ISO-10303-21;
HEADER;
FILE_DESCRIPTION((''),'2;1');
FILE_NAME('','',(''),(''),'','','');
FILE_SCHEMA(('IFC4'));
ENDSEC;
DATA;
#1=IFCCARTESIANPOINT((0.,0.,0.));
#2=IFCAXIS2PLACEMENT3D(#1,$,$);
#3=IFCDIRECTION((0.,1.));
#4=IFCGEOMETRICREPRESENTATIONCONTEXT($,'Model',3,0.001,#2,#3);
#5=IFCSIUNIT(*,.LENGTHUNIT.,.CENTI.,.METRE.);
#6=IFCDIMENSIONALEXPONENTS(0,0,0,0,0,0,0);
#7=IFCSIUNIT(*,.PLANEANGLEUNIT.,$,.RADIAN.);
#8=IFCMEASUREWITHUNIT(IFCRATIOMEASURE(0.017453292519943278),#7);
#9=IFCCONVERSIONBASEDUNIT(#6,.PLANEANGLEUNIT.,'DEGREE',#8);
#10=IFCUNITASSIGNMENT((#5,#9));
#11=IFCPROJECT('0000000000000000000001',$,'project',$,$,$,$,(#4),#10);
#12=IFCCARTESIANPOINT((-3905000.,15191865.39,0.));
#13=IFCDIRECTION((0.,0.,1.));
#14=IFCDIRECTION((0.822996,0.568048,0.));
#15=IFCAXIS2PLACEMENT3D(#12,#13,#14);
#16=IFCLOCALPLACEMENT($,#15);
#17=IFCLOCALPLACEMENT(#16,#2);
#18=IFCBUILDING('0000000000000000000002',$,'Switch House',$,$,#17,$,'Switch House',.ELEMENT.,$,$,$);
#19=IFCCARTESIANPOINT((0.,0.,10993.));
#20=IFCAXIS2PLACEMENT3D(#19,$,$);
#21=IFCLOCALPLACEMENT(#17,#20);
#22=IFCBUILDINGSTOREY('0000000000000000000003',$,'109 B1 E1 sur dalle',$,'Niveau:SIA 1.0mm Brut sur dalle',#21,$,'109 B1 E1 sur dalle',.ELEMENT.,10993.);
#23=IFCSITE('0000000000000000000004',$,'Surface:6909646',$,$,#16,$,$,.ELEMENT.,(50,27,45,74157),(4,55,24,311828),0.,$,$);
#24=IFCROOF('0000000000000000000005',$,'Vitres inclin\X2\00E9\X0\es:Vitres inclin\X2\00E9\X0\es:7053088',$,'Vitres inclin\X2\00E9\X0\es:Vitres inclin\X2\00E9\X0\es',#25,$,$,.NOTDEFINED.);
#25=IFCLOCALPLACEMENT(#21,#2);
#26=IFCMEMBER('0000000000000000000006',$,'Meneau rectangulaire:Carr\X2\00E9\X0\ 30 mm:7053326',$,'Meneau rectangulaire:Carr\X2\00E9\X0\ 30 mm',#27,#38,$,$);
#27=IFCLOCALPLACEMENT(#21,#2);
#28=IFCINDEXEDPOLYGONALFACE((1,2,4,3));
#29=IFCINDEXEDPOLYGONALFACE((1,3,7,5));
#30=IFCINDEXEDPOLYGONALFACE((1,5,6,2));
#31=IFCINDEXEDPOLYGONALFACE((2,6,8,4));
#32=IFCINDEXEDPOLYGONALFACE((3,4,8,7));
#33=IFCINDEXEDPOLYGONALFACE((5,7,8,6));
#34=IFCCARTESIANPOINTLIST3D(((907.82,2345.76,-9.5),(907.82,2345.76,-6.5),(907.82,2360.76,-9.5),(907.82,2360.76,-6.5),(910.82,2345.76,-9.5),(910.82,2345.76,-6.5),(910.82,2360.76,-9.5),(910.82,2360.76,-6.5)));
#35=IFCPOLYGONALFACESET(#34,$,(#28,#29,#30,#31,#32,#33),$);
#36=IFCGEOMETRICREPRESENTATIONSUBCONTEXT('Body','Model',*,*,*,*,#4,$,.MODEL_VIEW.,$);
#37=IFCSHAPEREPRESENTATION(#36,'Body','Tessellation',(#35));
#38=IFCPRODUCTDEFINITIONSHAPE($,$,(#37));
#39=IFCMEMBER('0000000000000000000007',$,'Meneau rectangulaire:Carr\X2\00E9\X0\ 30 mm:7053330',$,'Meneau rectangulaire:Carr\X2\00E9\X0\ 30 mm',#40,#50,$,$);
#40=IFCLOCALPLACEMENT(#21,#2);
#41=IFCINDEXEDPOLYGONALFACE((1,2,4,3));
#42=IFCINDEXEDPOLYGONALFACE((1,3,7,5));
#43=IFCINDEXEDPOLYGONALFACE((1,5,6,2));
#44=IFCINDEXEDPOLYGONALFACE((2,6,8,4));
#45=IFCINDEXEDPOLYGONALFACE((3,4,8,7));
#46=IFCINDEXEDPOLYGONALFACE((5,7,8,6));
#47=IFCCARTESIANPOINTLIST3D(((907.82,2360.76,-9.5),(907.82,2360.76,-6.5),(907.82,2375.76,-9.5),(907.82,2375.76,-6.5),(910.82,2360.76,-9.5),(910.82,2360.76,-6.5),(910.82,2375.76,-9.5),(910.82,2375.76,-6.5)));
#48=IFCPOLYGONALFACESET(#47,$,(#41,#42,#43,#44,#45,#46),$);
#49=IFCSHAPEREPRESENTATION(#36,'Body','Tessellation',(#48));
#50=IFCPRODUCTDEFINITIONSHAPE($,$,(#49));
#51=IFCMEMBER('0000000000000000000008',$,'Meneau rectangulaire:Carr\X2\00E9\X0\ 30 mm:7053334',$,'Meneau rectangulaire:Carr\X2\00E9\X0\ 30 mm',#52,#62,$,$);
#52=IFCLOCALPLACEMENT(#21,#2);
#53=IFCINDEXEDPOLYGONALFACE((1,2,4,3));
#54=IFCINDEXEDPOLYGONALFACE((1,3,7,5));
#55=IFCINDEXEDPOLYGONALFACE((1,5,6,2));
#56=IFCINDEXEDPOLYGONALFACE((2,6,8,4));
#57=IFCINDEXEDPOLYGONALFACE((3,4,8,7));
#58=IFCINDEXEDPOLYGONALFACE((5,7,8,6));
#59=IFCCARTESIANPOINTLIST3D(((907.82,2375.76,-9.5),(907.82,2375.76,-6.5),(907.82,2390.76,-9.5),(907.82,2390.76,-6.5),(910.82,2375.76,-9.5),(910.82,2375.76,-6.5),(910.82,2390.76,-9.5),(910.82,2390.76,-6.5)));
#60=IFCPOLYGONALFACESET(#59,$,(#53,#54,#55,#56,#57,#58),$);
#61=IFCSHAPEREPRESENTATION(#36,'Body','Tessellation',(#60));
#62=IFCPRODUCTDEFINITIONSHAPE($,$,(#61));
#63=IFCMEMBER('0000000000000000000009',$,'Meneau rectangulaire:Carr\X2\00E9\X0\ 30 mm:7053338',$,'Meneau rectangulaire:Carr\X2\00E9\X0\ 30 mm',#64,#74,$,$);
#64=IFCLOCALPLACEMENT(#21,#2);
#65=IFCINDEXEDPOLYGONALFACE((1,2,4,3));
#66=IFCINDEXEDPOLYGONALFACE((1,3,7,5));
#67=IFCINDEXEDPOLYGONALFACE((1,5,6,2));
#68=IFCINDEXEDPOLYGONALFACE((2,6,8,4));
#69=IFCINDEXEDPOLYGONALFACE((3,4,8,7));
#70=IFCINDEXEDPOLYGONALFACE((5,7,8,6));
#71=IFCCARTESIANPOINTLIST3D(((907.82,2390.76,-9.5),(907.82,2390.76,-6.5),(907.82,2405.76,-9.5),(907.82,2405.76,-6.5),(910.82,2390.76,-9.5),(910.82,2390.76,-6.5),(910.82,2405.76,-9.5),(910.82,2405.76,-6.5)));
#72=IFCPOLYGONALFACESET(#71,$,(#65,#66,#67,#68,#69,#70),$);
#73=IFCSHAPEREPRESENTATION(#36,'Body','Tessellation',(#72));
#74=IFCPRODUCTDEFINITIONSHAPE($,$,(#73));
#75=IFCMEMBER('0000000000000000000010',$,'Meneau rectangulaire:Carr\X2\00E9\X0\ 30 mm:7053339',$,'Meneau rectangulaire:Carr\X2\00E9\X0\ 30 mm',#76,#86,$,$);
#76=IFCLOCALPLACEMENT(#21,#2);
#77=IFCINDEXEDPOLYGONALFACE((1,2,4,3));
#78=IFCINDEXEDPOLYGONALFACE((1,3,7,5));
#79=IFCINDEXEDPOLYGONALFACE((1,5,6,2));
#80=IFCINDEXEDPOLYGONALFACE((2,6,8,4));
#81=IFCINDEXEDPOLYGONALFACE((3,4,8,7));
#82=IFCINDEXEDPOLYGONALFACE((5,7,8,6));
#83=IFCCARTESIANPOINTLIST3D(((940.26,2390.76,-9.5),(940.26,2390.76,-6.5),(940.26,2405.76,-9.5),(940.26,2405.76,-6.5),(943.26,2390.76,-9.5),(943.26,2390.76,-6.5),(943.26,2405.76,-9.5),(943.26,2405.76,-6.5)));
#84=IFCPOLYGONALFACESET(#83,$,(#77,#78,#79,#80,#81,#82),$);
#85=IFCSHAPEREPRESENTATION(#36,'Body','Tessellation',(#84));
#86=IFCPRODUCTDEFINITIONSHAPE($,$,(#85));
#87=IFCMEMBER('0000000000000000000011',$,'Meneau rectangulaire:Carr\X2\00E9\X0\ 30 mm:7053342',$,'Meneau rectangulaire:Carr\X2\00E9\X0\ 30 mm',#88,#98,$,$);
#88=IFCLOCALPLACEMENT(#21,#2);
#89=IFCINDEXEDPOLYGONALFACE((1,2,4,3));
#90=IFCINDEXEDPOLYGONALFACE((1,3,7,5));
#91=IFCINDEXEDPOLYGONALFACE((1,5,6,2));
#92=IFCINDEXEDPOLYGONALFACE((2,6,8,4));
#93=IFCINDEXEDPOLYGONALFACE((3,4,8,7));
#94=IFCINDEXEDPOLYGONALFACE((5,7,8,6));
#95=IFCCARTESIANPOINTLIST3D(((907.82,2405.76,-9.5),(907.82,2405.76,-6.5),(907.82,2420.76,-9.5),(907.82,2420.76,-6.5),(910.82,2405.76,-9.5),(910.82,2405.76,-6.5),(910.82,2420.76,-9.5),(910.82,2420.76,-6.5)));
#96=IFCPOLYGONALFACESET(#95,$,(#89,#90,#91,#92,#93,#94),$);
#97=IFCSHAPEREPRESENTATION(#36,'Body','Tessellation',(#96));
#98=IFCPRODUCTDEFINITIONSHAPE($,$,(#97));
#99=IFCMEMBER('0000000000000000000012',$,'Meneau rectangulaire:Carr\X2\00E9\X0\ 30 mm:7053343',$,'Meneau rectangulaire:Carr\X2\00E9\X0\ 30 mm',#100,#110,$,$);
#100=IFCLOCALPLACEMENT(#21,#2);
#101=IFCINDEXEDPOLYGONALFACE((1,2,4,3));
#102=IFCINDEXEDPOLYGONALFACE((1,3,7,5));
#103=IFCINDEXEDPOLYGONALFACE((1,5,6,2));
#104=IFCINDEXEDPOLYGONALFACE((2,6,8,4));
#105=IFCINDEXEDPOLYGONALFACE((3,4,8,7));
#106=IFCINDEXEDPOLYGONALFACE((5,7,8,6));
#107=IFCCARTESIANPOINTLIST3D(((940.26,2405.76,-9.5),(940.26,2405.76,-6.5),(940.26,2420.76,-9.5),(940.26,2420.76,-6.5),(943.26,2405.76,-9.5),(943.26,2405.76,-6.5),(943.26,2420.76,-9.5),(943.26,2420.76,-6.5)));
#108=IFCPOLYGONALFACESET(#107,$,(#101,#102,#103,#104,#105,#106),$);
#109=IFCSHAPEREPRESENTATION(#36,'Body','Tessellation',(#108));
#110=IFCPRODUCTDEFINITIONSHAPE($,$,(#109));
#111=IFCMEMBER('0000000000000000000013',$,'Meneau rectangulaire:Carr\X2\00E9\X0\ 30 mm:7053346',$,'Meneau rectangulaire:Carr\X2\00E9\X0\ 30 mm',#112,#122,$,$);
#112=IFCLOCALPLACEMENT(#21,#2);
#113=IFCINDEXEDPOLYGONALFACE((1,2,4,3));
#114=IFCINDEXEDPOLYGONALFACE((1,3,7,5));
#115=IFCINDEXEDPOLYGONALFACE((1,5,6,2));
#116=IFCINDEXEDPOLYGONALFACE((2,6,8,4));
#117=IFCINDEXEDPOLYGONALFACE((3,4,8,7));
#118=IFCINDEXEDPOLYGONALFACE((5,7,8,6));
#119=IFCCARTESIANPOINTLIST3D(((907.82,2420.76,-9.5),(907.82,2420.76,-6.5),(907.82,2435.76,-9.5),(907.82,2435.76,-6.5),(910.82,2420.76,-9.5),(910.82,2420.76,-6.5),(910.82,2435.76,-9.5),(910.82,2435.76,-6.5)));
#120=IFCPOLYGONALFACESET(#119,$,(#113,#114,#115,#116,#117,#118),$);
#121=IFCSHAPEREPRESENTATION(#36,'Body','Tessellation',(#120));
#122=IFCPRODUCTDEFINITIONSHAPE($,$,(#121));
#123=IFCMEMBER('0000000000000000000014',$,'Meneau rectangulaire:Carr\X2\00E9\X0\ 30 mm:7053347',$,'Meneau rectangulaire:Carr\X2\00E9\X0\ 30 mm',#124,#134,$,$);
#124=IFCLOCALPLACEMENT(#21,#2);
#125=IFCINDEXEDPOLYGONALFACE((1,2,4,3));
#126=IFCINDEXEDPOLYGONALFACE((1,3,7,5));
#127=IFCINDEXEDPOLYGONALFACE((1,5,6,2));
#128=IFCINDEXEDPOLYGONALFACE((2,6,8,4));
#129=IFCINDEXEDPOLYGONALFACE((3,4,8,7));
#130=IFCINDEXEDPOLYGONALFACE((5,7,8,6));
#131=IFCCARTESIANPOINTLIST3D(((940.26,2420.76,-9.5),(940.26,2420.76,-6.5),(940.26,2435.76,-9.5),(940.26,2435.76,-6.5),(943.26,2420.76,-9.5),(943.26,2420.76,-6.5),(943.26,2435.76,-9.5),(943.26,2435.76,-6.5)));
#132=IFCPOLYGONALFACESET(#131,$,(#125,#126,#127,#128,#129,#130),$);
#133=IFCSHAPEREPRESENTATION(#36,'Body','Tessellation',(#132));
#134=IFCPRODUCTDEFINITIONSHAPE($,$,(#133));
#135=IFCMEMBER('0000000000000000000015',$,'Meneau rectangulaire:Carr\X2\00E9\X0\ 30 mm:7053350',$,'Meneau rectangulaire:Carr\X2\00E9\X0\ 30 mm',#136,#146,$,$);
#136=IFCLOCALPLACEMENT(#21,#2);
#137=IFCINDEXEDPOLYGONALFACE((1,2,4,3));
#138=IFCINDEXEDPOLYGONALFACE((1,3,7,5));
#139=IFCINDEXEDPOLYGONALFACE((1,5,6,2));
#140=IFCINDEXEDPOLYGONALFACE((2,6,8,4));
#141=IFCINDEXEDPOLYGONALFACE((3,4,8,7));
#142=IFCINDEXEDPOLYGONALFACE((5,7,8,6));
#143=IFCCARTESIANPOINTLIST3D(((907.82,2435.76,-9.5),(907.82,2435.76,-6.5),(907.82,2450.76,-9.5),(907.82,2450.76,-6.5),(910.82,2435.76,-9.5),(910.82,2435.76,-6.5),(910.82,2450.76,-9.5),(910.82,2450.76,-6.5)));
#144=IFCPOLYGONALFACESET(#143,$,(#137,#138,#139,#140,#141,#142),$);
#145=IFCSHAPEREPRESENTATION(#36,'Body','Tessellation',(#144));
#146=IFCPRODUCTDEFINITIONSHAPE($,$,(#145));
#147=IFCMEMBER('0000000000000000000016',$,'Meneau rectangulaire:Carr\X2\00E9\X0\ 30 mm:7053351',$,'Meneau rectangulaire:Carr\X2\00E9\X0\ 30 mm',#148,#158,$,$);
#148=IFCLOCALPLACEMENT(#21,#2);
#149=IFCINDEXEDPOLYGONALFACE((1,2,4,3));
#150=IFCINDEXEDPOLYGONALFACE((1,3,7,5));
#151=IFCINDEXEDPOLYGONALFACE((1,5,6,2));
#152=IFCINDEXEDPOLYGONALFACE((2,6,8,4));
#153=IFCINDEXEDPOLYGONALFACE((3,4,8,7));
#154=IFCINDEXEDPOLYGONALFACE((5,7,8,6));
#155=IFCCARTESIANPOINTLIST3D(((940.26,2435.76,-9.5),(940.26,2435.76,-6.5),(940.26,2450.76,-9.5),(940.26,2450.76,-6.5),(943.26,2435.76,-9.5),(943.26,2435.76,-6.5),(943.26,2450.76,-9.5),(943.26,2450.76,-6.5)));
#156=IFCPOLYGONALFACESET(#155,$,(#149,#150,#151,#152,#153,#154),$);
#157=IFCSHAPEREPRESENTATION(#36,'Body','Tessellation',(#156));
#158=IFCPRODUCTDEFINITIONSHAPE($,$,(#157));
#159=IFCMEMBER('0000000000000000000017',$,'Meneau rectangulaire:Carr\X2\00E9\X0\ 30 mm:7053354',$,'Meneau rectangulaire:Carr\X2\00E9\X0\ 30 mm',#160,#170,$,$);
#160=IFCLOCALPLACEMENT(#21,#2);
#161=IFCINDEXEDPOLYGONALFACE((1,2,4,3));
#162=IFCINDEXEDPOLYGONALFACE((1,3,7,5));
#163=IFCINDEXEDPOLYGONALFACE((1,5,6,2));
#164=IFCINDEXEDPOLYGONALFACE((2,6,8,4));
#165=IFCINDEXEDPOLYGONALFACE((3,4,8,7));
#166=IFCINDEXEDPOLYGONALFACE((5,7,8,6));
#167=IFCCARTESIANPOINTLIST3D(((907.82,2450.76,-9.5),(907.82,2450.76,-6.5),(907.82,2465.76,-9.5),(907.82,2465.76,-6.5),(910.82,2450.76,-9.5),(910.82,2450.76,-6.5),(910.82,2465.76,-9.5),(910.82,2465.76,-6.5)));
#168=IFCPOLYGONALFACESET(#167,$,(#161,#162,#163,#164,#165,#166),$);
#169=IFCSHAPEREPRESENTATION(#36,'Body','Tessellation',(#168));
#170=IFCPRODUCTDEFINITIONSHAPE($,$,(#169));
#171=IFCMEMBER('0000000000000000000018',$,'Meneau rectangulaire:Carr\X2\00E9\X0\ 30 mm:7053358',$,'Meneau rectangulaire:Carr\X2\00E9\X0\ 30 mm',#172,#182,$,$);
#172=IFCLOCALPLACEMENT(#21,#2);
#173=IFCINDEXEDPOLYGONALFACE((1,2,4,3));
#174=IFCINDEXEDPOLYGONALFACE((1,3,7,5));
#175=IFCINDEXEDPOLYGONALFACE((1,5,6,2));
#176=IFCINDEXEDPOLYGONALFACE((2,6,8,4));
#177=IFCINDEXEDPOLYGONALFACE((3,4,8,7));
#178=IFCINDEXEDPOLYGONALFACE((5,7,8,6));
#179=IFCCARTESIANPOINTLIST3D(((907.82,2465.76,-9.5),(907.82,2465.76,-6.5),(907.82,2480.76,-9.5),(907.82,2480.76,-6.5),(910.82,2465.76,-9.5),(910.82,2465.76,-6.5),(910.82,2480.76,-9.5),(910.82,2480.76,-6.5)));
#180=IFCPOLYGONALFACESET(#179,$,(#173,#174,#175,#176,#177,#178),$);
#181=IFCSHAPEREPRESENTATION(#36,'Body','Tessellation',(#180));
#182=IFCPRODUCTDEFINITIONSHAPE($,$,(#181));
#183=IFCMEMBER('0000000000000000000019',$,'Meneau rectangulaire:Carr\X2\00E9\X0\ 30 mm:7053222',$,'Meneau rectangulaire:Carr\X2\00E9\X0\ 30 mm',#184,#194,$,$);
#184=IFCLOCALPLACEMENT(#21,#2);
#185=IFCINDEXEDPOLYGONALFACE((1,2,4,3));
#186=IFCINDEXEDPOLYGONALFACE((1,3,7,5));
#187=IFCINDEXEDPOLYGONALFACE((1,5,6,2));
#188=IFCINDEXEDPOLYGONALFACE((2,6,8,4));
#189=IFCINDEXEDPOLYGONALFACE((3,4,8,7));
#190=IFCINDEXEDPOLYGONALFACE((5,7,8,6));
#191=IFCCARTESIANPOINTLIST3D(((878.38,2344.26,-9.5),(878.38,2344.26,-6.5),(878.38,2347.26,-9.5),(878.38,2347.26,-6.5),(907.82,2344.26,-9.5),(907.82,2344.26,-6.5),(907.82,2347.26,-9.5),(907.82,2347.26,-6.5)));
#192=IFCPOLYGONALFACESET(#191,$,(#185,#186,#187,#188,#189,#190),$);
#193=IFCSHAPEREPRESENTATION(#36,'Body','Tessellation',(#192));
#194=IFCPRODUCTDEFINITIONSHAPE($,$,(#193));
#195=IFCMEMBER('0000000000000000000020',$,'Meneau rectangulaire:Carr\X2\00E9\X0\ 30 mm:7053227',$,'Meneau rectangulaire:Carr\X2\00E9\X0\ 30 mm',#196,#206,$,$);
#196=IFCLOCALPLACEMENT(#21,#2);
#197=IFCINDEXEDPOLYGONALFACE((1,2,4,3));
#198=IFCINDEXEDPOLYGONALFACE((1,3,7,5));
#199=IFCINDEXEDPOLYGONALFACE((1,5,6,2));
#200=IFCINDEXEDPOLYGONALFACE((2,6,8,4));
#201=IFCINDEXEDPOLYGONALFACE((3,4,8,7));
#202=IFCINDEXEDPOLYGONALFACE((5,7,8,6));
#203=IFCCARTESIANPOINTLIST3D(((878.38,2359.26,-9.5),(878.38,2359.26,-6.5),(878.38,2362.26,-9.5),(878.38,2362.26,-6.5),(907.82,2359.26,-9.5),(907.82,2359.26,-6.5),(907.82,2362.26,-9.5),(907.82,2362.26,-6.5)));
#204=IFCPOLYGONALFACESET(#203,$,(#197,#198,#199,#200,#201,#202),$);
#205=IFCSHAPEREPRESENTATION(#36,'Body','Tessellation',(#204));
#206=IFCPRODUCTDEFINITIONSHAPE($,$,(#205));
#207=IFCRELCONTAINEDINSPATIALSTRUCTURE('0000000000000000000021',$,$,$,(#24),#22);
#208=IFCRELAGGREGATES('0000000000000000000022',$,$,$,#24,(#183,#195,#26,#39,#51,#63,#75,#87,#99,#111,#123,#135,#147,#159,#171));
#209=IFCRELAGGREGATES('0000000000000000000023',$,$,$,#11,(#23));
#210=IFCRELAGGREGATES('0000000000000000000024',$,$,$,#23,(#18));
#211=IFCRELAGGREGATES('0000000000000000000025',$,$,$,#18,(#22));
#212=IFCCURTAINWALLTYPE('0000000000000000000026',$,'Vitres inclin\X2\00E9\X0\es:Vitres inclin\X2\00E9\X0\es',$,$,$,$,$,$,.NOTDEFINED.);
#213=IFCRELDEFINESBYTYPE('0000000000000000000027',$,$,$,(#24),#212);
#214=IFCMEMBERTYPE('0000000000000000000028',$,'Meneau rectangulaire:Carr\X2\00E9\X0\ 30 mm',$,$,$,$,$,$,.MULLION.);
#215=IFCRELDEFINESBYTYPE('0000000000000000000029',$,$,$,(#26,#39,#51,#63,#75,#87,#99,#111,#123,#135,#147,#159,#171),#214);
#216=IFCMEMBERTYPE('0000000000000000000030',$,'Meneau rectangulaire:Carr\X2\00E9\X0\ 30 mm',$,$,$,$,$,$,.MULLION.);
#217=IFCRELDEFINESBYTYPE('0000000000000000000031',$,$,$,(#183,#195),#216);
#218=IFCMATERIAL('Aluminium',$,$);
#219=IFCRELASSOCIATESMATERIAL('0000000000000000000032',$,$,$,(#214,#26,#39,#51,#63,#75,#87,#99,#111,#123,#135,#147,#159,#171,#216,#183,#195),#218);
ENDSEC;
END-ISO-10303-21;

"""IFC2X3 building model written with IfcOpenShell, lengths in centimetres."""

from ifc_helpers import new_model, entity, si_unit, converted_unit, direction, frame, origin, origin_2d_with_axis, place, context, subcontext, project, spatial, rectangle, extrude, source, transform, mapped, material, type_object, type_shapes, element, aggregate, save


model = new_model("IFC2X3")

# Units and contexts
model_context = context("Model", 3, precision=0.001, world=origin(), true_north=direction((0.0, 1.0)))
body_context = subcontext(model_context, "Body", "Model", "MODEL_VIEW")
ifc_project = project(units=[si_unit("LENGTHUNIT", "METRE", prefix="CENTI"), converted_unit("PLANEANGLEUNIT", "DEGREE", entity("IfcRatioMeasure", 0.017453292519943278), si_unit("PLANEANGLEUNIT", "RADIAN"), dimensions=[0, 0, 0, 0, 0, 0, 0])], contexts=[model_context])

# Site, building, storey
site_placement = place(None, frame((-3905000.0, 15191865.39, 0.0), z_axis=(0.0, 0.0, 1.0), x_axis=(0.822996, 0.568048, 0.0)))
site = spatial("IfcSite", under=ifc_project, at=site_placement, Name="Surface:6909646", CompositionType="ELEMENT", RefLatitude=(50, 27, 45, 74157), RefLongitude=(4, 55, 24, 311828), RefElevation=0.0)
building_placement = place(site_placement, origin())
building = spatial("IfcBuilding", under=site, at=building_placement, Name="Switch House", LongName="Switch House", CompositionType="ELEMENT")
storey_placement = place(building_placement, frame((0.0, 0.0, 10993.0)))
storey = spatial("IfcBuildingStorey", under=building, at=storey_placement, Name="109 B1 E1 sur dalle", ObjectType="Niveau:SIA 1.0mm Brut sur dalle", LongName="109 B1 E1 sur dalle", CompositionType="ELEMENT", Elevation=10993.0)

# Roof, members
curtain_wall_type = type_object("IfcCurtainWallType", Name="Vitres inclinées:Vitres inclinées", PredefinedType="NOTDEFINED")
roof_placement = place(storey_placement, frame((0.0, 0.0, -10993.0)))
roof = element("IfcRoof", 1, at=roof_placement, inside=storey, type_object=curtain_wall_type, Name="Vitres inclinées:Vitres inclinées:7053088", ObjectType="Vitres inclinées:Vitres inclinées", ShapeType="NOTDEFINED")
ifc_material = material(Name="Aluminium")
member_type_1 = type_object("IfcMemberType", Name="Meneau rectangulaire:Carré 30 mm", PredefinedType="MULLION", material=ifc_material)
shared_shape_1 = source(origin(), body_context, "Body", "SweptSolid", [
    extrude(rectangle(XDim=3.0, YDim=3.0, at=origin_2d_with_axis()), frame((0.0, 0.0, -15.0), z_axis=(0.0, 0.0, 1.0), x_axis=(0.0, -1.0, 0.0)), (0.0, 0.0, 1.0), 15.0),
])
type_shapes(member_type_1, [shared_shape_1])
member_1_placement = place(roof_placement, frame((909.32, 2360.76, 10985.0), z_axis=(0.0, 1.0, 0.0), x_axis=(1.0, 0.0, 0.0)))
member_1 = element("IfcMember", 2, at=member_1_placement, type_object=member_type_1, material=ifc_material, Name="Meneau rectangulaire:Carré 30 mm:7053326", ObjectType="Meneau rectangulaire:Carré 30 mm", context=body_context, shape_type="MappedRepresentation", body=[
    mapped(shared_shape_1, transform((0.0, 0.0, 0.0), scale=1.0)),
])
member_2_placement = place(roof_placement, frame((909.32, 2375.76, 10985.0), z_axis=(0.0, 1.0, 0.0), x_axis=(1.0, 0.0, 0.0)))
member_2 = element("IfcMember", 3, at=member_2_placement, type_object=member_type_1, material=ifc_material, Name="Meneau rectangulaire:Carré 30 mm:7053330", ObjectType="Meneau rectangulaire:Carré 30 mm", context=body_context, shape_type="MappedRepresentation", body=[
    mapped(shared_shape_1, transform((0.0, 0.0, 0.0), scale=1.0)),
])
member_3_placement = place(roof_placement, frame((909.32, 2390.76, 10985.0), z_axis=(0.0, 1.0, 0.0), x_axis=(1.0, 0.0, 0.0)))
member_3 = element("IfcMember", 4, at=member_3_placement, type_object=member_type_1, material=ifc_material, Name="Meneau rectangulaire:Carré 30 mm:7053334", ObjectType="Meneau rectangulaire:Carré 30 mm", context=body_context, shape_type="MappedRepresentation", body=[
    mapped(shared_shape_1, transform((0.0, 0.0, 0.0), scale=1.0)),
])
member_4_placement = place(roof_placement, frame((909.32, 2405.76, 10985.0), z_axis=(0.0, 1.0, 0.0), x_axis=(1.0, 0.0, 0.0)))
member_4 = element("IfcMember", 5, at=member_4_placement, type_object=member_type_1, material=ifc_material, Name="Meneau rectangulaire:Carré 30 mm:7053338", ObjectType="Meneau rectangulaire:Carré 30 mm", context=body_context, shape_type="MappedRepresentation", body=[
    mapped(shared_shape_1, transform((0.0, 0.0, 0.0), scale=1.0)),
])
member_5_placement = place(roof_placement, frame((941.76, 2405.76, 10985.0), z_axis=(0.0, 1.0, 0.0), x_axis=(1.0, 0.0, 0.0)))
member_5 = element("IfcMember", 6, at=member_5_placement, type_object=member_type_1, material=ifc_material, Name="Meneau rectangulaire:Carré 30 mm:7053339", ObjectType="Meneau rectangulaire:Carré 30 mm", context=body_context, shape_type="MappedRepresentation", body=[
    mapped(shared_shape_1, transform((0.0, 0.0, 0.0), scale=1.0)),
])
member_6_placement = place(roof_placement, frame((909.32, 2420.76, 10985.0), z_axis=(0.0, 1.0, 0.0), x_axis=(1.0, 0.0, 0.0)))
member_6 = element("IfcMember", 7, at=member_6_placement, type_object=member_type_1, material=ifc_material, Name="Meneau rectangulaire:Carré 30 mm:7053342", ObjectType="Meneau rectangulaire:Carré 30 mm", context=body_context, shape_type="MappedRepresentation", body=[
    mapped(shared_shape_1, transform((0.0, 0.0, 0.0), scale=1.0)),
])
member_7_placement = place(roof_placement, frame((941.76, 2420.76, 10985.0), z_axis=(0.0, 1.0, 0.0), x_axis=(1.0, 0.0, 0.0)))
member_7 = element("IfcMember", 8, at=member_7_placement, type_object=member_type_1, material=ifc_material, Name="Meneau rectangulaire:Carré 30 mm:7053343", ObjectType="Meneau rectangulaire:Carré 30 mm", context=body_context, shape_type="MappedRepresentation", body=[
    mapped(shared_shape_1, transform((0.0, 0.0, 0.0), scale=1.0)),
])
member_8_placement = place(roof_placement, frame((909.32, 2435.76, 10985.0), z_axis=(0.0, 1.0, 0.0), x_axis=(1.0, 0.0, 0.0)))
member_8 = element("IfcMember", 9, at=member_8_placement, type_object=member_type_1, material=ifc_material, Name="Meneau rectangulaire:Carré 30 mm:7053346", ObjectType="Meneau rectangulaire:Carré 30 mm", context=body_context, shape_type="MappedRepresentation", body=[
    mapped(shared_shape_1, transform((0.0, 0.0, 0.0), scale=1.0)),
])
member_9_placement = place(roof_placement, frame((941.76, 2435.76, 10985.0), z_axis=(0.0, 1.0, 0.0), x_axis=(1.0, 0.0, 0.0)))
member_9 = element("IfcMember", 10, at=member_9_placement, type_object=member_type_1, material=ifc_material, Name="Meneau rectangulaire:Carré 30 mm:7053347", ObjectType="Meneau rectangulaire:Carré 30 mm", context=body_context, shape_type="MappedRepresentation", body=[
    mapped(shared_shape_1, transform((0.0, 0.0, 0.0), scale=1.0)),
])
member_10_placement = place(roof_placement, frame((909.32, 2450.76, 10985.0), z_axis=(0.0, 1.0, 0.0), x_axis=(1.0, 0.0, 0.0)))
member_10 = element("IfcMember", 11, at=member_10_placement, type_object=member_type_1, material=ifc_material, Name="Meneau rectangulaire:Carré 30 mm:7053350", ObjectType="Meneau rectangulaire:Carré 30 mm", context=body_context, shape_type="MappedRepresentation", body=[
    mapped(shared_shape_1, transform((0.0, 0.0, 0.0), scale=1.0)),
])
member_11_placement = place(roof_placement, frame((941.76, 2450.76, 10985.0), z_axis=(0.0, 1.0, 0.0), x_axis=(1.0, 0.0, 0.0)))
member_11 = element("IfcMember", 12, at=member_11_placement, type_object=member_type_1, material=ifc_material, Name="Meneau rectangulaire:Carré 30 mm:7053351", ObjectType="Meneau rectangulaire:Carré 30 mm", context=body_context, shape_type="MappedRepresentation", body=[
    mapped(shared_shape_1, transform((0.0, 0.0, 0.0), scale=1.0)),
])
member_12_placement = place(roof_placement, frame((909.32, 2465.76, 10985.0), z_axis=(0.0, 1.0, 0.0), x_axis=(1.0, 0.0, 0.0)))
member_12 = element("IfcMember", 13, at=member_12_placement, type_object=member_type_1, material=ifc_material, Name="Meneau rectangulaire:Carré 30 mm:7053354", ObjectType="Meneau rectangulaire:Carré 30 mm", context=body_context, shape_type="MappedRepresentation", body=[
    mapped(shared_shape_1, transform((0.0, 0.0, 0.0), scale=1.0)),
])
member_13_placement = place(roof_placement, frame((909.32, 2480.76, 10985.0), z_axis=(0.0, 1.0, 0.0), x_axis=(1.0, 0.0, 0.0)))
member_13 = element("IfcMember", 14, at=member_13_placement, type_object=member_type_1, material=ifc_material, Name="Meneau rectangulaire:Carré 30 mm:7053358", ObjectType="Meneau rectangulaire:Carré 30 mm", context=body_context, shape_type="MappedRepresentation", body=[
    mapped(shared_shape_1, transform((0.0, 0.0, 0.0), scale=1.0)),
])
member_type_2 = type_object("IfcMemberType", Name="Meneau rectangulaire:Carré 30 mm", PredefinedType="MULLION", material=ifc_material)
shared_shape_2 = source(origin(), body_context, "Body", "SweptSolid", [
    extrude(rectangle(XDim=3.0, YDim=3.0, at=origin_2d_with_axis()), frame((0.0, 0.0, -29.44), z_axis=(0.0, 0.0, 1.0), x_axis=(0.0, -1.0, 0.0)), (0.0, 0.0, 1.0), 29.44),
])
type_shapes(member_type_2, [shared_shape_2])
member_14_placement = place(roof_placement, frame((878.38, 2345.76, 10985.0), z_axis=(-1.0, 0.0, 0.0), x_axis=(0.0, 1.0, 0.0)))
member_14 = element("IfcMember", 15, at=member_14_placement, type_object=member_type_2, material=ifc_material, Name="Meneau rectangulaire:Carré 30 mm:7053222", ObjectType="Meneau rectangulaire:Carré 30 mm", context=body_context, shape_type="MappedRepresentation", body=[
    mapped(shared_shape_2, transform((0.0, 0.0, 0.0), scale=1.0)),
])
member_15_placement = place(roof_placement, frame((878.38, 2360.76, 10985.0), z_axis=(-1.0, 0.0, 0.0), x_axis=(0.0, 1.0, 0.0)))
member_15 = element("IfcMember", 16, at=member_15_placement, type_object=member_type_2, material=ifc_material, Name="Meneau rectangulaire:Carré 30 mm:7053227", ObjectType="Meneau rectangulaire:Carré 30 mm", context=body_context, shape_type="MappedRepresentation", body=[
    mapped(shared_shape_2, transform((0.0, 0.0, 0.0), scale=1.0)),
])
aggregate(roof, [member_14, member_15, member_1, member_2, member_3, member_4, member_5, member_6, member_7, member_8, member_9, member_10, member_11, member_12, member_13])

save(model, "model.ifc")
